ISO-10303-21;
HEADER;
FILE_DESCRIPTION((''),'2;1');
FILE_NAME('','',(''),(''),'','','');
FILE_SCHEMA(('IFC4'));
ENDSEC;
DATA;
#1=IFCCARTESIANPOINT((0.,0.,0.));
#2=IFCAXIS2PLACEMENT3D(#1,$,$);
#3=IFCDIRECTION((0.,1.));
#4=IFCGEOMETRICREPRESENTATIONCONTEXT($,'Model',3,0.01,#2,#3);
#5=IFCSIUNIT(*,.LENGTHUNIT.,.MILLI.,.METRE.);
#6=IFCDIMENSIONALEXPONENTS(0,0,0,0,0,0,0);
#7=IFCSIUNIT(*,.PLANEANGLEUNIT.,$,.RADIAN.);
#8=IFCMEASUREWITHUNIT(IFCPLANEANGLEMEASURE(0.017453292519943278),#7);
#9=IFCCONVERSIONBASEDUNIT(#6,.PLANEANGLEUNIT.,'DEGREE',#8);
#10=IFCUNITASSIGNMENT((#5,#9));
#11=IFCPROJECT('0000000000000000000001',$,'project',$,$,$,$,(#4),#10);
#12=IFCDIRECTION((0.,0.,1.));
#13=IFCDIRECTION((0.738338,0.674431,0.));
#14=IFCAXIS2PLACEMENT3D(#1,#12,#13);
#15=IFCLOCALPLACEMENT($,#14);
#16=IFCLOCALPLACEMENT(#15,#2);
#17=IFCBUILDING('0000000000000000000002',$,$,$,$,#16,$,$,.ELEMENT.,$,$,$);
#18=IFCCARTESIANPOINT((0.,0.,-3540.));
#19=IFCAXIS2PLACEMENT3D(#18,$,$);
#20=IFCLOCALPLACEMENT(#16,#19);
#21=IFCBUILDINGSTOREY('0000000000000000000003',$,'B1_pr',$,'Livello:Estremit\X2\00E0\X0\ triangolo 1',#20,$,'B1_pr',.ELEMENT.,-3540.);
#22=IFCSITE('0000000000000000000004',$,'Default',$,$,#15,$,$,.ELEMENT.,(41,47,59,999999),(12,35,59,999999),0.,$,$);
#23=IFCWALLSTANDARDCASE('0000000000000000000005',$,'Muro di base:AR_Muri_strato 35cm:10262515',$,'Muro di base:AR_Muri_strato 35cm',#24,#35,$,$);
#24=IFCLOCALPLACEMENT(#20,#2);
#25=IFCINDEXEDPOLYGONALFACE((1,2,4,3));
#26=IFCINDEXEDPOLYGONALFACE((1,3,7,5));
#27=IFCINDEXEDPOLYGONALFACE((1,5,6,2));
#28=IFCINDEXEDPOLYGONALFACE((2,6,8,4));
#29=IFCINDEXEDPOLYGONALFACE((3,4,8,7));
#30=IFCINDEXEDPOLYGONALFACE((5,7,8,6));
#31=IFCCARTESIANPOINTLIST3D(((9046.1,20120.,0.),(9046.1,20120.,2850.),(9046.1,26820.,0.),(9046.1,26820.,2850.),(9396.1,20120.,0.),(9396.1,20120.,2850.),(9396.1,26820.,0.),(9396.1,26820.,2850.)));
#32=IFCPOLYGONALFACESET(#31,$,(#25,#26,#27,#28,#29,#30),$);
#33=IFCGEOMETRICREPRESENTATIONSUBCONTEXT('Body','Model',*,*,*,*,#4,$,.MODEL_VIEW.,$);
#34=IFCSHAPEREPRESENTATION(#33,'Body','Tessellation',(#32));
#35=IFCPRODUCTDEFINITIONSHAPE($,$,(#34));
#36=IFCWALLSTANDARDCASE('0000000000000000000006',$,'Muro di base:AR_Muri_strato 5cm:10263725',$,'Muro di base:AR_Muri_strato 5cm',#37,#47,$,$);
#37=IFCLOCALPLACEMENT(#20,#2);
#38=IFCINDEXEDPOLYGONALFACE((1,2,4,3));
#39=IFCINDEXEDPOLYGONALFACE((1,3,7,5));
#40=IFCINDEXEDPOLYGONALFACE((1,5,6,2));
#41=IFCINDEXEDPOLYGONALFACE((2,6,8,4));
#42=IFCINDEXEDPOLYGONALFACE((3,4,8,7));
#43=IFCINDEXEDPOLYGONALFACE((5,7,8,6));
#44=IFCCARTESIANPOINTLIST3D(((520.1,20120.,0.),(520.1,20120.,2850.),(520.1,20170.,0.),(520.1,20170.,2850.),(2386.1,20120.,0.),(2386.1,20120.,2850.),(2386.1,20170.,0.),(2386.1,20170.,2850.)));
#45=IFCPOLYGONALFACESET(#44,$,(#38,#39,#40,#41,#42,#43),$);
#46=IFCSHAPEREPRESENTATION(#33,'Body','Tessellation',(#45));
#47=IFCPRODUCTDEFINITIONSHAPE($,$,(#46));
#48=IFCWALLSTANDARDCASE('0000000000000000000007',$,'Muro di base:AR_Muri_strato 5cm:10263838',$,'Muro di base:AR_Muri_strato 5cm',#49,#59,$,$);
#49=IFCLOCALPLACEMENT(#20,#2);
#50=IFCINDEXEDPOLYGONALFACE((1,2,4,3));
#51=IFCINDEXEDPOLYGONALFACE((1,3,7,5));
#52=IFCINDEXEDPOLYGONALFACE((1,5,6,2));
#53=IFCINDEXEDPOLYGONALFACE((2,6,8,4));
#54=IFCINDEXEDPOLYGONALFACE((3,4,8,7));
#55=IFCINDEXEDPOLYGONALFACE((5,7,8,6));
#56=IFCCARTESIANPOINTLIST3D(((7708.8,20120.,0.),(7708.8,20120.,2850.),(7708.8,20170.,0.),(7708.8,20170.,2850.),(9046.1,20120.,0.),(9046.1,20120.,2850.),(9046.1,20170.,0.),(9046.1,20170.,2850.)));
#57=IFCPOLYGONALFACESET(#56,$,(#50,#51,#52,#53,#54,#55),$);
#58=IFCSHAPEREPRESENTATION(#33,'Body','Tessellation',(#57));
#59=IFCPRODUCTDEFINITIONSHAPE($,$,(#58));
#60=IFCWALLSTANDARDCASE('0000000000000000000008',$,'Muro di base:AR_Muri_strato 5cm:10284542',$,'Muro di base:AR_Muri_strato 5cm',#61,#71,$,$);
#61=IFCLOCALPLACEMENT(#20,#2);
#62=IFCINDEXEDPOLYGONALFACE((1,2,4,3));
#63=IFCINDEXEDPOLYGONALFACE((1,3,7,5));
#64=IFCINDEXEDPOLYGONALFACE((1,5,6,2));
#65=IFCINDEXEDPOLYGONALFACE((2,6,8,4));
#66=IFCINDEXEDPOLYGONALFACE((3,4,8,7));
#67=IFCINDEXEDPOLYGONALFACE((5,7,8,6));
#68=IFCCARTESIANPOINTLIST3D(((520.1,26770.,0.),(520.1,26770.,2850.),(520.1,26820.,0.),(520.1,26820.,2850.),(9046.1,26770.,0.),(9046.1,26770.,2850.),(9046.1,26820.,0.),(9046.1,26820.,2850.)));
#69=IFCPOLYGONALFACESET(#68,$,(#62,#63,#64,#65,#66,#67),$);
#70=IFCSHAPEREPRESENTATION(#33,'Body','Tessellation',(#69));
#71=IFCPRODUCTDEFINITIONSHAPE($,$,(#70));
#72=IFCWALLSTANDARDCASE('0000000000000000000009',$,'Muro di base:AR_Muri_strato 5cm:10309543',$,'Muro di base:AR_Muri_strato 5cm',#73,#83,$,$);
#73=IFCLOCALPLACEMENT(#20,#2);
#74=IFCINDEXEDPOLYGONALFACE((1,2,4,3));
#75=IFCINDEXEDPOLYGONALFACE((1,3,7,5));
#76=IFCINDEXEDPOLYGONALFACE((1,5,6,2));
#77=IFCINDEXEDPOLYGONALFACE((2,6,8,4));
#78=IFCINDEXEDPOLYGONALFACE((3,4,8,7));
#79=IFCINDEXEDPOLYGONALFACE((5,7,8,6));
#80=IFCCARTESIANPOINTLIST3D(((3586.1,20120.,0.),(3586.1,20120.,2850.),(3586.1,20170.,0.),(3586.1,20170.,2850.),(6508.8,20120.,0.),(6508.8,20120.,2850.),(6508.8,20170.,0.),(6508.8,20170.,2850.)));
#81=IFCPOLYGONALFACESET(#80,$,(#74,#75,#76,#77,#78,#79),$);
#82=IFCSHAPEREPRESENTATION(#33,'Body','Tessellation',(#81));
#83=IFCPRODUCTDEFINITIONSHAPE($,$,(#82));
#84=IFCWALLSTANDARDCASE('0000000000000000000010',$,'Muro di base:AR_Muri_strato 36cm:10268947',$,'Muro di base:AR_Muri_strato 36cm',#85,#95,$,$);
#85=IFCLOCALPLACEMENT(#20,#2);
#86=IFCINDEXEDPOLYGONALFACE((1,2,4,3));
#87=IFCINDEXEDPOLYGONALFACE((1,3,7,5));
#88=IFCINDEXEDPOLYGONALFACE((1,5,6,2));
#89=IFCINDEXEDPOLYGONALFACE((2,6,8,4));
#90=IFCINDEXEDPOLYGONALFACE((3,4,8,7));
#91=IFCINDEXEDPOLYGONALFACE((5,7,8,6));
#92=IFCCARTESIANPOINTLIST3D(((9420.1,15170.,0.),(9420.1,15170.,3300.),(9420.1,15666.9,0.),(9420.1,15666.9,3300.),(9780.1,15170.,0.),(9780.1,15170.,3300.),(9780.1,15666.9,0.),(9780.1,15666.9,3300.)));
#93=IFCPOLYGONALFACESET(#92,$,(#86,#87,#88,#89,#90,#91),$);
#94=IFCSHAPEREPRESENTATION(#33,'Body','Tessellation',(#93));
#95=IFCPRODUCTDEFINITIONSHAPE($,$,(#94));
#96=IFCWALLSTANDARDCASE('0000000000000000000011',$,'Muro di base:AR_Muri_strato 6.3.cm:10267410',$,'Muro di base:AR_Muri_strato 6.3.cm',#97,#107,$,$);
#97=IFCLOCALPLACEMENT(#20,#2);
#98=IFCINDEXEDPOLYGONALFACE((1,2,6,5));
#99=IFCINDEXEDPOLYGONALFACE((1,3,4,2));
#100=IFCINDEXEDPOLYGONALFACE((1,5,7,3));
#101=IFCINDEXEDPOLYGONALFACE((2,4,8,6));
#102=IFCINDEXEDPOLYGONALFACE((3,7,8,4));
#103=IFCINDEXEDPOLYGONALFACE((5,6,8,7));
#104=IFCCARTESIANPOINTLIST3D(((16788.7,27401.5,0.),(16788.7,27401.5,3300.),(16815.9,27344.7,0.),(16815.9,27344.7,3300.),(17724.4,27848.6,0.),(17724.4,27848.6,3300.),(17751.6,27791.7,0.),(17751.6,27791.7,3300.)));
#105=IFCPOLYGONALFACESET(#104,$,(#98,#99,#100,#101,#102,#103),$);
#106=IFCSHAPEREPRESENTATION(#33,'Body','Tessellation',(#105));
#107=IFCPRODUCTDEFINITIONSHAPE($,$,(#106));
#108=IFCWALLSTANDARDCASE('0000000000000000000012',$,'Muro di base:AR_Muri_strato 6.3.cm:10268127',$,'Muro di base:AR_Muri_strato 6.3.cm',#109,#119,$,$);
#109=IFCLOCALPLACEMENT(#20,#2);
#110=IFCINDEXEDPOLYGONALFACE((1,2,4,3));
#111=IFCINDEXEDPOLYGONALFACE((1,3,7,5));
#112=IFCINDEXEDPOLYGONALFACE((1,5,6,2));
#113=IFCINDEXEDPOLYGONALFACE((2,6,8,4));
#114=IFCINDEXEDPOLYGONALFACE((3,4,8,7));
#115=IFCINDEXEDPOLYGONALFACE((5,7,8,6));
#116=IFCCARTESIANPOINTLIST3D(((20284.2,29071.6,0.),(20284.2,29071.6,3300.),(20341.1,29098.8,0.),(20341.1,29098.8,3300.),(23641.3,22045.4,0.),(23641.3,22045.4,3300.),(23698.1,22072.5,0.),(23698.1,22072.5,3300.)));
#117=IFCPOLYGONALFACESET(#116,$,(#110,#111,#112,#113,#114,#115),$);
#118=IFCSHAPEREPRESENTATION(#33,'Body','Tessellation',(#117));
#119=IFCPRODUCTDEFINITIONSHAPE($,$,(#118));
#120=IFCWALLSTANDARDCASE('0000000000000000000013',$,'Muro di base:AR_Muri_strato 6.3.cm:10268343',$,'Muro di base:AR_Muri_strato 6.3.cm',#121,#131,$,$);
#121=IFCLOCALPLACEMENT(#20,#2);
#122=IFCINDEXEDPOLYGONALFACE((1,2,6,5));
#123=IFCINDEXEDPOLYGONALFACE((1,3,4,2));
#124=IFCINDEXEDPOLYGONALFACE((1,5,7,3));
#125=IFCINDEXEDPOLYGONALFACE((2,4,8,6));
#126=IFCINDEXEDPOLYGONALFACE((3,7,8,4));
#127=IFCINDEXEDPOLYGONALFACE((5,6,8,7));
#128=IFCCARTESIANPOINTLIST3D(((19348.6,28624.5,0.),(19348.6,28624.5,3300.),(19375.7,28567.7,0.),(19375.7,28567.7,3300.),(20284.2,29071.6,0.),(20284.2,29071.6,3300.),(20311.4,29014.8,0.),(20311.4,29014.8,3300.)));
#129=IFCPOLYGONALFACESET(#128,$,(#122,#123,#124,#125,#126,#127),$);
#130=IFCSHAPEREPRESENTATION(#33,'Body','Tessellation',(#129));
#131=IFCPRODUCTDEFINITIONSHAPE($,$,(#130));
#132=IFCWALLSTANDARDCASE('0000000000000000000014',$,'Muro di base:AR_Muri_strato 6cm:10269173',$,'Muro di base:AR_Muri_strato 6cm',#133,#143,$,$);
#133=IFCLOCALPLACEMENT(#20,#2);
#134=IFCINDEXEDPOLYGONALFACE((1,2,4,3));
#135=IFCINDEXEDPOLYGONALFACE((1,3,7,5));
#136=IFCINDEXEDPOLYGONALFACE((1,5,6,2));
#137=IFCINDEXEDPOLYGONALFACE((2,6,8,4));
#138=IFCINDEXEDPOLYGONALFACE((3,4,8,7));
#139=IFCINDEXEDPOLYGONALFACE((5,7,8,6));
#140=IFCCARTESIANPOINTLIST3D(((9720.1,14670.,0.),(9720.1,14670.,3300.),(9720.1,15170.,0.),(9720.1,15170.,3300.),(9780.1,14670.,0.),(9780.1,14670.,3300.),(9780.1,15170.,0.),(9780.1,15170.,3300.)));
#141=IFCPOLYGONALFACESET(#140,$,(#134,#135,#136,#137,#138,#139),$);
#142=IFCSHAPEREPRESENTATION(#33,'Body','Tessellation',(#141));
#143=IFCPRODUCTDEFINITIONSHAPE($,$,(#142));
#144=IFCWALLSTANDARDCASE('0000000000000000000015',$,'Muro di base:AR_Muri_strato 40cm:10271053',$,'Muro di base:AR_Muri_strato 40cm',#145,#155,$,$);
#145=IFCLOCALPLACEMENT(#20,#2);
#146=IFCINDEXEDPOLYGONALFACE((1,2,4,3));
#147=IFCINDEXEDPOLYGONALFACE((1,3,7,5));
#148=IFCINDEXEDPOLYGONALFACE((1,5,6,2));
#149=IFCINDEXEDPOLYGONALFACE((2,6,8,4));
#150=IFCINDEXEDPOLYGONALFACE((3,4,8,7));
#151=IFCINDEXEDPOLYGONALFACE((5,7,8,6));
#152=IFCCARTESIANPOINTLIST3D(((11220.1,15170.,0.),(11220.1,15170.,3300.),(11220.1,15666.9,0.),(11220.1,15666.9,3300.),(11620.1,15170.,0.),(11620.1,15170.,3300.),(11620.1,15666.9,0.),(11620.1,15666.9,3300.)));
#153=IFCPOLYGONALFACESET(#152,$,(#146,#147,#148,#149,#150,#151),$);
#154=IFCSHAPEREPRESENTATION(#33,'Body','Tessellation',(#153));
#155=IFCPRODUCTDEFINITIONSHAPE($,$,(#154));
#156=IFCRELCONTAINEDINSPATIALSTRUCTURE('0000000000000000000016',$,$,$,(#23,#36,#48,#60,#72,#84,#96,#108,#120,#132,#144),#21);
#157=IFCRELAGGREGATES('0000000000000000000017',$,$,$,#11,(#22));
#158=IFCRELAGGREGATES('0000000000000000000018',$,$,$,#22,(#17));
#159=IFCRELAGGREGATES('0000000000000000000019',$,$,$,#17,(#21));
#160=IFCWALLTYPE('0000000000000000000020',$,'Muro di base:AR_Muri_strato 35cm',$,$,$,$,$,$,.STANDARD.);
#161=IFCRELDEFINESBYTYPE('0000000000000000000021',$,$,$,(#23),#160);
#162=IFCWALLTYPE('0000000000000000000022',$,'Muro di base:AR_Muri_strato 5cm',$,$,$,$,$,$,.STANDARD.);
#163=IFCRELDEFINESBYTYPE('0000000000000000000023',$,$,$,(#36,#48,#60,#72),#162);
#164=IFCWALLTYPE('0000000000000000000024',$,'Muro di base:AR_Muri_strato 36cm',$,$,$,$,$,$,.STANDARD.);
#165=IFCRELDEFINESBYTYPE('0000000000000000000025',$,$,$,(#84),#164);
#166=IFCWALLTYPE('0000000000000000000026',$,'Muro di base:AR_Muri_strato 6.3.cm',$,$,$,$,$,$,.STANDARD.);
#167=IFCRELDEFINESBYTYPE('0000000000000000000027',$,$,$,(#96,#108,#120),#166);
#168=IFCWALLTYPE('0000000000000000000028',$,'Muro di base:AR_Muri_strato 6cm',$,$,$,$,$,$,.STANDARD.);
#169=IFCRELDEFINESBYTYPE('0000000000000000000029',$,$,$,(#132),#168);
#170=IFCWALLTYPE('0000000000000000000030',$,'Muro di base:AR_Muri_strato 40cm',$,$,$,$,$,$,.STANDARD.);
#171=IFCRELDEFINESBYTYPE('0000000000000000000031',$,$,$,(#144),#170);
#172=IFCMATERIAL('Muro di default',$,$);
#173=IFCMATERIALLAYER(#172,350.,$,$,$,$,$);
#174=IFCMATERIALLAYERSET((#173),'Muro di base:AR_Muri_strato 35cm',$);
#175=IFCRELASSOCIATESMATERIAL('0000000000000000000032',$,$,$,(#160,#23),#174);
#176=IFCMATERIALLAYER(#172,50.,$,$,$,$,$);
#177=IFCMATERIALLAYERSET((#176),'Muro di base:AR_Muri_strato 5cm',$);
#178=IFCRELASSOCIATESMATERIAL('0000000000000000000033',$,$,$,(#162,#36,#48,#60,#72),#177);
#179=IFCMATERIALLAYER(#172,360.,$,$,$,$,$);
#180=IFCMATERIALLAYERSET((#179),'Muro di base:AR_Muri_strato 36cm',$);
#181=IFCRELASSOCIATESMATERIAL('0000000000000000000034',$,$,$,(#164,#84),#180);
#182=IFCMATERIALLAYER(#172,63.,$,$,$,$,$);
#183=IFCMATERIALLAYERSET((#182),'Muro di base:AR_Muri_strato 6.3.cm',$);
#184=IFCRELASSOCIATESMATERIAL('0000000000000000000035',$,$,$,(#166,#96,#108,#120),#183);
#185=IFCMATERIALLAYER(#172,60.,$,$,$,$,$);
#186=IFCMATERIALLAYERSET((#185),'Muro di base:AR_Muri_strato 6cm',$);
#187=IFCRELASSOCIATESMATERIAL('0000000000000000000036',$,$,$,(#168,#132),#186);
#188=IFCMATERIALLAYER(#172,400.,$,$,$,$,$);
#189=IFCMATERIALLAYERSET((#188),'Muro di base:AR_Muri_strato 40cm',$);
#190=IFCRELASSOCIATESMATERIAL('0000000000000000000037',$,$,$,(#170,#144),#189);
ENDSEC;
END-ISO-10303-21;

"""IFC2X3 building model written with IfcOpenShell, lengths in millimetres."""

from ifc_helpers import new_model, entity, si_unit, converted_unit, direction, frame, frame_2d, origin, place, context, subcontext, project, spatial, rectangle, extrude, material, layer, layer_set, layer_usage, type_object, element, save


model = new_model("IFC2X3")

# Units and contexts
model_context = context("Model", 3, precision=0.01, world=origin(), true_north=direction((0.0, 1.0)))
body_context = subcontext(model_context, "Body", "Model", "MODEL_VIEW")
ifc_project = project(units=[si_unit("LENGTHUNIT", "METRE", prefix="MILLI"), converted_unit("PLANEANGLEUNIT", "DEGREE", entity("IfcPlaneAngleMeasure", 0.017453292519943278), si_unit("PLANEANGLEUNIT", "RADIAN"), dimensions=[0, 0, 0, 0, 0, 0, 0])], contexts=[model_context])

# Site, building, storey
site_placement = place(None, frame((0.0, 0.0, 0.0), z_axis=(0.0, 0.0, 1.0), x_axis=(0.738338, 0.674431, 0.0)))
site = spatial("IfcSite", under=ifc_project, at=site_placement, Name="Default", CompositionType="ELEMENT", RefLatitude=(41, 47, 59, 999999), RefLongitude=(12, 35, 59, 999999), RefElevation=0.0)
building_placement = place(site_placement, origin())
building = spatial("IfcBuilding", under=site, at=building_placement, CompositionType="ELEMENT")
storey_placement = place(building_placement, frame((0.0, 0.0, -3540.0)))
storey = spatial("IfcBuildingStorey", under=building, at=storey_placement, Name="B1_pr", ObjectType="Livello:Estremità triangolo 1", LongName="B1_pr", CompositionType="ELEMENT", Elevation=-3540.0)

# Shared definitions
ifc_material = material(Name="Muro di default")

# Walls
ifc_layer_1 = layer(ifc_material, 350.0)
ifc_layer_set_1 = layer_set([ifc_layer_1], Name="Muro di base:AR_Muri_strato 35cm")
ifc_layer_usage_1 = layer_usage(ifc_layer_set_1, "AXIS2", "NEGATIVE", 175.0)
wall_type_1 = type_object("IfcWallType", Name="Muro di base:AR_Muri_strato 35cm", PredefinedType="STANDARD", material=ifc_layer_set_1)
wall_1_placement = place(storey_placement, frame((9221.1, 20120.0, 0.0), z_axis=(0.0, 0.0, 1.0), x_axis=(0.0, 1.0, 0.0)))
element("IfcWallStandardCase", 1, at=wall_1_placement, inside=storey, type_object=wall_type_1, material=ifc_layer_usage_1, Name="Muro di base:AR_Muri_strato 35cm:10262515", ObjectType="Muro di base:AR_Muri_strato 35cm", context=body_context, shape_type="SweptSolid", body=[
    extrude(rectangle(XDim=6700.0, YDim=350.0, at=frame_2d((3350.0, 0.0), x_axis=(-1.0, 0.0))), origin(), (0.0, 0.0, 1.0), 2850.0),
])
ifc_layer_2 = layer(ifc_material, 50.0)
ifc_layer_set_2 = layer_set([ifc_layer_2], Name="Muro di base:AR_Muri_strato 5cm")
ifc_layer_usage_2 = layer_usage(ifc_layer_set_2, "AXIS2", "NEGATIVE", 25.0)
wall_type_2 = type_object("IfcWallType", Name="Muro di base:AR_Muri_strato 5cm", PredefinedType="STANDARD", material=ifc_layer_set_2)
wall_2_placement = place(storey_placement, frame((520.1, 20145.0, 0.0)))
element("IfcWallStandardCase", 2, at=wall_2_placement, inside=storey, type_object=wall_type_2, material=ifc_layer_usage_2, Name="Muro di base:AR_Muri_strato 5cm:10263725", ObjectType="Muro di base:AR_Muri_strato 5cm", context=body_context, shape_type="SweptSolid", body=[
    extrude(rectangle(XDim=1866.0, YDim=50.0, at=frame_2d((933.0, 0.0), x_axis=(-1.0, 0.0))), origin(), (0.0, 0.0, 1.0), 2850.0),
])
ifc_layer_usage_3 = layer_usage(ifc_layer_set_2, "AXIS2", "NEGATIVE", 25.0)
wall_3_placement = place(storey_placement, frame((7708.8, 20145.0, 0.0)))
element("IfcWallStandardCase", 3, at=wall_3_placement, inside=storey, type_object=wall_type_2, material=ifc_layer_usage_3, Name="Muro di base:AR_Muri_strato 5cm:10263838", ObjectType="Muro di base:AR_Muri_strato 5cm", context=body_context, shape_type="SweptSolid", body=[
    extrude(rectangle(XDim=1337.3, YDim=50.0, at=frame_2d((668.7, 0.0), x_axis=(-1.0, 0.0))), origin(), (0.0, 0.0, 1.0), 2850.0),
])
ifc_layer_usage_4 = layer_usage(ifc_layer_set_2, "AXIS2", "NEGATIVE", 25.0)
wall_4_placement = place(storey_placement, frame((9046.1, 26795.0, 0.0), z_axis=(0.0, 0.0, 1.0), x_axis=(-1.0, 0.0, 0.0)))
element("IfcWallStandardCase", 4, at=wall_4_placement, inside=storey, type_object=wall_type_2, material=ifc_layer_usage_4, Name="Muro di base:AR_Muri_strato 5cm:10284542", ObjectType="Muro di base:AR_Muri_strato 5cm", context=body_context, shape_type="SweptSolid", body=[
    extrude(rectangle(XDim=8526.0, YDim=50.0, at=frame_2d((4263.0, 0.0), x_axis=(-1.0, 0.0))), origin(), (0.0, 0.0, 1.0), 2850.0),
])
ifc_layer_usage_5 = layer_usage(ifc_layer_set_2, "AXIS2", "NEGATIVE", 25.0)
wall_5_placement = place(storey_placement, frame((3586.1, 20145.0, 0.0)))
element("IfcWallStandardCase", 5, at=wall_5_placement, inside=storey, type_object=wall_type_2, material=ifc_layer_usage_5, Name="Muro di base:AR_Muri_strato 5cm:10309543", ObjectType="Muro di base:AR_Muri_strato 5cm", context=body_context, shape_type="SweptSolid", body=[
    extrude(rectangle(XDim=2922.7, YDim=50.0, at=frame_2d((1461.3, 0.0), x_axis=(-1.0, 0.0))), origin(), (0.0, 0.0, 1.0), 2850.0),
])
ifc_layer_3 = layer(ifc_material, 360.0)
ifc_layer_set_3 = layer_set([ifc_layer_3], Name="Muro di base:AR_Muri_strato 36cm")
ifc_layer_usage_6 = layer_usage(ifc_layer_set_3, "AXIS2", "NEGATIVE", 180.0)
wall_type_3 = type_object("IfcWallType", Name="Muro di base:AR_Muri_strato 36cm", PredefinedType="STANDARD", material=ifc_layer_set_3)
wall_6_placement = place(storey_placement, frame((9600.1, 15170.0, 0.0), z_axis=(0.0, 0.0, 1.0), x_axis=(0.0, 1.0, 0.0)))
element("IfcWallStandardCase", 6, at=wall_6_placement, inside=storey, type_object=wall_type_3, material=ifc_layer_usage_6, Name="Muro di base:AR_Muri_strato 36cm:10268947", ObjectType="Muro di base:AR_Muri_strato 36cm", context=body_context, shape_type="SweptSolid", body=[
    extrude(rectangle(XDim=496.9, YDim=360.0, at=frame_2d((248.5, 0.0), x_axis=(-1.0, 0.0))), origin(), (0.0, 0.0, 1.0), 3300.0),
])
ifc_layer_4 = layer(ifc_material, 63.0)
ifc_layer_set_4 = layer_set([ifc_layer_4], Name="Muro di base:AR_Muri_strato 6.3.cm")
ifc_layer_usage_7 = layer_usage(ifc_layer_set_4, "AXIS2", "NEGATIVE", 31.5)
wall_type_4 = type_object("IfcWallType", Name="Muro di base:AR_Muri_strato 6.3.cm", PredefinedType="STANDARD", material=ifc_layer_set_4)
wall_7_placement = place(storey_placement, frame((16802.3, 27373.1, 0.0), z_axis=(0.0, 0.0, 1.0), x_axis=(0.902302, 0.431105, 0.0)))
element("IfcWallStandardCase", 7, at=wall_7_placement, inside=storey, type_object=wall_type_4, material=ifc_layer_usage_7, Name="Muro di base:AR_Muri_strato 6.3.cm:10267410", ObjectType="Muro di base:AR_Muri_strato 6.3.cm", context=body_context, shape_type="SweptSolid", body=[
    extrude(rectangle(XDim=1037.0, YDim=63.0, at=frame_2d((518.5, 0.0), x_axis=(-1.0, 0.0))), origin(), (0.0, 0.0, 1.0), 3300.0),
])
ifc_layer_usage_8 = layer_usage(ifc_layer_set_4, "AXIS2", "NEGATIVE", 31.5)
wall_8_placement = place(storey_placement, frame((20312.7, 29085.2, 0.0), z_axis=(0.0, 0.0, 1.0), x_axis=(0.431105, -0.902302, 0.0)))
element("IfcWallStandardCase", 8, at=wall_8_placement, inside=storey, type_object=wall_type_4, material=ifc_layer_usage_8, Name="Muro di base:AR_Muri_strato 6.3.cm:10268127", ObjectType="Muro di base:AR_Muri_strato 6.3.cm", context=body_context, shape_type="SweptSolid", body=[
    extrude(rectangle(XDim=7787.0, YDim=63.0, at=frame_2d((3893.5, 0.0), x_axis=(-1.0, 0.0))), origin(), (0.0, 0.0, 1.0), 3300.0),
])
ifc_layer_usage_9 = layer_usage(ifc_layer_set_4, "AXIS2", "NEGATIVE", 31.5)
wall_9_placement = place(storey_placement, frame((19362.1, 28596.1, 0.0), z_axis=(0.0, 0.0, 1.0), x_axis=(0.902302, 0.431105, 0.0)))
element("IfcWallStandardCase", 9, at=wall_9_placement, inside=storey, type_object=wall_type_4, material=ifc_layer_usage_9, Name="Muro di base:AR_Muri_strato 6.3.cm:10268343", ObjectType="Muro di base:AR_Muri_strato 6.3.cm", context=body_context, shape_type="SweptSolid", body=[
    extrude(rectangle(XDim=1037.0, YDim=63.0, at=frame_2d((518.5, 0.0), x_axis=(-1.0, 0.0))), origin(), (0.0, 0.0, 1.0), 3300.0),
])
ifc_layer_5 = layer(ifc_material, 60.0)
ifc_layer_set_5 = layer_set([ifc_layer_5], Name="Muro di base:AR_Muri_strato 6cm")
ifc_layer_usage_10 = layer_usage(ifc_layer_set_5, "AXIS2", "NEGATIVE", 30.0)
wall_type_5 = type_object("IfcWallType", Name="Muro di base:AR_Muri_strato 6cm", PredefinedType="STANDARD", material=ifc_layer_set_5)
wall_10_placement = place(storey_placement, frame((9750.1, 14670.0, 0.0), z_axis=(0.0, 0.0, 1.0), x_axis=(0.0, 1.0, 0.0)))
element("IfcWallStandardCase", 10, at=wall_10_placement, inside=storey, type_object=wall_type_5, material=ifc_layer_usage_10, Name="Muro di base:AR_Muri_strato 6cm:10269173", ObjectType="Muro di base:AR_Muri_strato 6cm", context=body_context, shape_type="SweptSolid", body=[
    extrude(rectangle(XDim=500.0, YDim=60.0, at=frame_2d((250.0, 0.0), x_axis=(-1.0, 0.0))), origin(), (0.0, 0.0, 1.0), 3300.0),
])
ifc_layer_6 = layer(ifc_material, 400.0)
ifc_layer_set_6 = layer_set([ifc_layer_6], Name="Muro di base:AR_Muri_strato 40cm")
ifc_layer_usage_11 = layer_usage(ifc_layer_set_6, "AXIS2", "NEGATIVE", 200.0)
wall_type_6 = type_object("IfcWallType", Name="Muro di base:AR_Muri_strato 40cm", PredefinedType="STANDARD", material=ifc_layer_set_6)
wall_11_placement = place(storey_placement, frame((11420.1, 15170.0, 0.0), z_axis=(0.0, 0.0, 1.0), x_axis=(0.0, 1.0, 0.0)))
element("IfcWallStandardCase", 11, at=wall_11_placement, inside=storey, type_object=wall_type_6, material=ifc_layer_usage_11, Name="Muro di base:AR_Muri_strato 40cm:10271053", ObjectType="Muro di base:AR_Muri_strato 40cm", context=body_context, shape_type="SweptSolid", body=[
    extrude(rectangle(XDim=496.9, YDim=400.0, at=frame_2d((248.5, 0.0), x_axis=(-1.0, 0.0))), origin(), (0.0, 0.0, 1.0), 3300.0),
])

save(model, "model.ifc")
